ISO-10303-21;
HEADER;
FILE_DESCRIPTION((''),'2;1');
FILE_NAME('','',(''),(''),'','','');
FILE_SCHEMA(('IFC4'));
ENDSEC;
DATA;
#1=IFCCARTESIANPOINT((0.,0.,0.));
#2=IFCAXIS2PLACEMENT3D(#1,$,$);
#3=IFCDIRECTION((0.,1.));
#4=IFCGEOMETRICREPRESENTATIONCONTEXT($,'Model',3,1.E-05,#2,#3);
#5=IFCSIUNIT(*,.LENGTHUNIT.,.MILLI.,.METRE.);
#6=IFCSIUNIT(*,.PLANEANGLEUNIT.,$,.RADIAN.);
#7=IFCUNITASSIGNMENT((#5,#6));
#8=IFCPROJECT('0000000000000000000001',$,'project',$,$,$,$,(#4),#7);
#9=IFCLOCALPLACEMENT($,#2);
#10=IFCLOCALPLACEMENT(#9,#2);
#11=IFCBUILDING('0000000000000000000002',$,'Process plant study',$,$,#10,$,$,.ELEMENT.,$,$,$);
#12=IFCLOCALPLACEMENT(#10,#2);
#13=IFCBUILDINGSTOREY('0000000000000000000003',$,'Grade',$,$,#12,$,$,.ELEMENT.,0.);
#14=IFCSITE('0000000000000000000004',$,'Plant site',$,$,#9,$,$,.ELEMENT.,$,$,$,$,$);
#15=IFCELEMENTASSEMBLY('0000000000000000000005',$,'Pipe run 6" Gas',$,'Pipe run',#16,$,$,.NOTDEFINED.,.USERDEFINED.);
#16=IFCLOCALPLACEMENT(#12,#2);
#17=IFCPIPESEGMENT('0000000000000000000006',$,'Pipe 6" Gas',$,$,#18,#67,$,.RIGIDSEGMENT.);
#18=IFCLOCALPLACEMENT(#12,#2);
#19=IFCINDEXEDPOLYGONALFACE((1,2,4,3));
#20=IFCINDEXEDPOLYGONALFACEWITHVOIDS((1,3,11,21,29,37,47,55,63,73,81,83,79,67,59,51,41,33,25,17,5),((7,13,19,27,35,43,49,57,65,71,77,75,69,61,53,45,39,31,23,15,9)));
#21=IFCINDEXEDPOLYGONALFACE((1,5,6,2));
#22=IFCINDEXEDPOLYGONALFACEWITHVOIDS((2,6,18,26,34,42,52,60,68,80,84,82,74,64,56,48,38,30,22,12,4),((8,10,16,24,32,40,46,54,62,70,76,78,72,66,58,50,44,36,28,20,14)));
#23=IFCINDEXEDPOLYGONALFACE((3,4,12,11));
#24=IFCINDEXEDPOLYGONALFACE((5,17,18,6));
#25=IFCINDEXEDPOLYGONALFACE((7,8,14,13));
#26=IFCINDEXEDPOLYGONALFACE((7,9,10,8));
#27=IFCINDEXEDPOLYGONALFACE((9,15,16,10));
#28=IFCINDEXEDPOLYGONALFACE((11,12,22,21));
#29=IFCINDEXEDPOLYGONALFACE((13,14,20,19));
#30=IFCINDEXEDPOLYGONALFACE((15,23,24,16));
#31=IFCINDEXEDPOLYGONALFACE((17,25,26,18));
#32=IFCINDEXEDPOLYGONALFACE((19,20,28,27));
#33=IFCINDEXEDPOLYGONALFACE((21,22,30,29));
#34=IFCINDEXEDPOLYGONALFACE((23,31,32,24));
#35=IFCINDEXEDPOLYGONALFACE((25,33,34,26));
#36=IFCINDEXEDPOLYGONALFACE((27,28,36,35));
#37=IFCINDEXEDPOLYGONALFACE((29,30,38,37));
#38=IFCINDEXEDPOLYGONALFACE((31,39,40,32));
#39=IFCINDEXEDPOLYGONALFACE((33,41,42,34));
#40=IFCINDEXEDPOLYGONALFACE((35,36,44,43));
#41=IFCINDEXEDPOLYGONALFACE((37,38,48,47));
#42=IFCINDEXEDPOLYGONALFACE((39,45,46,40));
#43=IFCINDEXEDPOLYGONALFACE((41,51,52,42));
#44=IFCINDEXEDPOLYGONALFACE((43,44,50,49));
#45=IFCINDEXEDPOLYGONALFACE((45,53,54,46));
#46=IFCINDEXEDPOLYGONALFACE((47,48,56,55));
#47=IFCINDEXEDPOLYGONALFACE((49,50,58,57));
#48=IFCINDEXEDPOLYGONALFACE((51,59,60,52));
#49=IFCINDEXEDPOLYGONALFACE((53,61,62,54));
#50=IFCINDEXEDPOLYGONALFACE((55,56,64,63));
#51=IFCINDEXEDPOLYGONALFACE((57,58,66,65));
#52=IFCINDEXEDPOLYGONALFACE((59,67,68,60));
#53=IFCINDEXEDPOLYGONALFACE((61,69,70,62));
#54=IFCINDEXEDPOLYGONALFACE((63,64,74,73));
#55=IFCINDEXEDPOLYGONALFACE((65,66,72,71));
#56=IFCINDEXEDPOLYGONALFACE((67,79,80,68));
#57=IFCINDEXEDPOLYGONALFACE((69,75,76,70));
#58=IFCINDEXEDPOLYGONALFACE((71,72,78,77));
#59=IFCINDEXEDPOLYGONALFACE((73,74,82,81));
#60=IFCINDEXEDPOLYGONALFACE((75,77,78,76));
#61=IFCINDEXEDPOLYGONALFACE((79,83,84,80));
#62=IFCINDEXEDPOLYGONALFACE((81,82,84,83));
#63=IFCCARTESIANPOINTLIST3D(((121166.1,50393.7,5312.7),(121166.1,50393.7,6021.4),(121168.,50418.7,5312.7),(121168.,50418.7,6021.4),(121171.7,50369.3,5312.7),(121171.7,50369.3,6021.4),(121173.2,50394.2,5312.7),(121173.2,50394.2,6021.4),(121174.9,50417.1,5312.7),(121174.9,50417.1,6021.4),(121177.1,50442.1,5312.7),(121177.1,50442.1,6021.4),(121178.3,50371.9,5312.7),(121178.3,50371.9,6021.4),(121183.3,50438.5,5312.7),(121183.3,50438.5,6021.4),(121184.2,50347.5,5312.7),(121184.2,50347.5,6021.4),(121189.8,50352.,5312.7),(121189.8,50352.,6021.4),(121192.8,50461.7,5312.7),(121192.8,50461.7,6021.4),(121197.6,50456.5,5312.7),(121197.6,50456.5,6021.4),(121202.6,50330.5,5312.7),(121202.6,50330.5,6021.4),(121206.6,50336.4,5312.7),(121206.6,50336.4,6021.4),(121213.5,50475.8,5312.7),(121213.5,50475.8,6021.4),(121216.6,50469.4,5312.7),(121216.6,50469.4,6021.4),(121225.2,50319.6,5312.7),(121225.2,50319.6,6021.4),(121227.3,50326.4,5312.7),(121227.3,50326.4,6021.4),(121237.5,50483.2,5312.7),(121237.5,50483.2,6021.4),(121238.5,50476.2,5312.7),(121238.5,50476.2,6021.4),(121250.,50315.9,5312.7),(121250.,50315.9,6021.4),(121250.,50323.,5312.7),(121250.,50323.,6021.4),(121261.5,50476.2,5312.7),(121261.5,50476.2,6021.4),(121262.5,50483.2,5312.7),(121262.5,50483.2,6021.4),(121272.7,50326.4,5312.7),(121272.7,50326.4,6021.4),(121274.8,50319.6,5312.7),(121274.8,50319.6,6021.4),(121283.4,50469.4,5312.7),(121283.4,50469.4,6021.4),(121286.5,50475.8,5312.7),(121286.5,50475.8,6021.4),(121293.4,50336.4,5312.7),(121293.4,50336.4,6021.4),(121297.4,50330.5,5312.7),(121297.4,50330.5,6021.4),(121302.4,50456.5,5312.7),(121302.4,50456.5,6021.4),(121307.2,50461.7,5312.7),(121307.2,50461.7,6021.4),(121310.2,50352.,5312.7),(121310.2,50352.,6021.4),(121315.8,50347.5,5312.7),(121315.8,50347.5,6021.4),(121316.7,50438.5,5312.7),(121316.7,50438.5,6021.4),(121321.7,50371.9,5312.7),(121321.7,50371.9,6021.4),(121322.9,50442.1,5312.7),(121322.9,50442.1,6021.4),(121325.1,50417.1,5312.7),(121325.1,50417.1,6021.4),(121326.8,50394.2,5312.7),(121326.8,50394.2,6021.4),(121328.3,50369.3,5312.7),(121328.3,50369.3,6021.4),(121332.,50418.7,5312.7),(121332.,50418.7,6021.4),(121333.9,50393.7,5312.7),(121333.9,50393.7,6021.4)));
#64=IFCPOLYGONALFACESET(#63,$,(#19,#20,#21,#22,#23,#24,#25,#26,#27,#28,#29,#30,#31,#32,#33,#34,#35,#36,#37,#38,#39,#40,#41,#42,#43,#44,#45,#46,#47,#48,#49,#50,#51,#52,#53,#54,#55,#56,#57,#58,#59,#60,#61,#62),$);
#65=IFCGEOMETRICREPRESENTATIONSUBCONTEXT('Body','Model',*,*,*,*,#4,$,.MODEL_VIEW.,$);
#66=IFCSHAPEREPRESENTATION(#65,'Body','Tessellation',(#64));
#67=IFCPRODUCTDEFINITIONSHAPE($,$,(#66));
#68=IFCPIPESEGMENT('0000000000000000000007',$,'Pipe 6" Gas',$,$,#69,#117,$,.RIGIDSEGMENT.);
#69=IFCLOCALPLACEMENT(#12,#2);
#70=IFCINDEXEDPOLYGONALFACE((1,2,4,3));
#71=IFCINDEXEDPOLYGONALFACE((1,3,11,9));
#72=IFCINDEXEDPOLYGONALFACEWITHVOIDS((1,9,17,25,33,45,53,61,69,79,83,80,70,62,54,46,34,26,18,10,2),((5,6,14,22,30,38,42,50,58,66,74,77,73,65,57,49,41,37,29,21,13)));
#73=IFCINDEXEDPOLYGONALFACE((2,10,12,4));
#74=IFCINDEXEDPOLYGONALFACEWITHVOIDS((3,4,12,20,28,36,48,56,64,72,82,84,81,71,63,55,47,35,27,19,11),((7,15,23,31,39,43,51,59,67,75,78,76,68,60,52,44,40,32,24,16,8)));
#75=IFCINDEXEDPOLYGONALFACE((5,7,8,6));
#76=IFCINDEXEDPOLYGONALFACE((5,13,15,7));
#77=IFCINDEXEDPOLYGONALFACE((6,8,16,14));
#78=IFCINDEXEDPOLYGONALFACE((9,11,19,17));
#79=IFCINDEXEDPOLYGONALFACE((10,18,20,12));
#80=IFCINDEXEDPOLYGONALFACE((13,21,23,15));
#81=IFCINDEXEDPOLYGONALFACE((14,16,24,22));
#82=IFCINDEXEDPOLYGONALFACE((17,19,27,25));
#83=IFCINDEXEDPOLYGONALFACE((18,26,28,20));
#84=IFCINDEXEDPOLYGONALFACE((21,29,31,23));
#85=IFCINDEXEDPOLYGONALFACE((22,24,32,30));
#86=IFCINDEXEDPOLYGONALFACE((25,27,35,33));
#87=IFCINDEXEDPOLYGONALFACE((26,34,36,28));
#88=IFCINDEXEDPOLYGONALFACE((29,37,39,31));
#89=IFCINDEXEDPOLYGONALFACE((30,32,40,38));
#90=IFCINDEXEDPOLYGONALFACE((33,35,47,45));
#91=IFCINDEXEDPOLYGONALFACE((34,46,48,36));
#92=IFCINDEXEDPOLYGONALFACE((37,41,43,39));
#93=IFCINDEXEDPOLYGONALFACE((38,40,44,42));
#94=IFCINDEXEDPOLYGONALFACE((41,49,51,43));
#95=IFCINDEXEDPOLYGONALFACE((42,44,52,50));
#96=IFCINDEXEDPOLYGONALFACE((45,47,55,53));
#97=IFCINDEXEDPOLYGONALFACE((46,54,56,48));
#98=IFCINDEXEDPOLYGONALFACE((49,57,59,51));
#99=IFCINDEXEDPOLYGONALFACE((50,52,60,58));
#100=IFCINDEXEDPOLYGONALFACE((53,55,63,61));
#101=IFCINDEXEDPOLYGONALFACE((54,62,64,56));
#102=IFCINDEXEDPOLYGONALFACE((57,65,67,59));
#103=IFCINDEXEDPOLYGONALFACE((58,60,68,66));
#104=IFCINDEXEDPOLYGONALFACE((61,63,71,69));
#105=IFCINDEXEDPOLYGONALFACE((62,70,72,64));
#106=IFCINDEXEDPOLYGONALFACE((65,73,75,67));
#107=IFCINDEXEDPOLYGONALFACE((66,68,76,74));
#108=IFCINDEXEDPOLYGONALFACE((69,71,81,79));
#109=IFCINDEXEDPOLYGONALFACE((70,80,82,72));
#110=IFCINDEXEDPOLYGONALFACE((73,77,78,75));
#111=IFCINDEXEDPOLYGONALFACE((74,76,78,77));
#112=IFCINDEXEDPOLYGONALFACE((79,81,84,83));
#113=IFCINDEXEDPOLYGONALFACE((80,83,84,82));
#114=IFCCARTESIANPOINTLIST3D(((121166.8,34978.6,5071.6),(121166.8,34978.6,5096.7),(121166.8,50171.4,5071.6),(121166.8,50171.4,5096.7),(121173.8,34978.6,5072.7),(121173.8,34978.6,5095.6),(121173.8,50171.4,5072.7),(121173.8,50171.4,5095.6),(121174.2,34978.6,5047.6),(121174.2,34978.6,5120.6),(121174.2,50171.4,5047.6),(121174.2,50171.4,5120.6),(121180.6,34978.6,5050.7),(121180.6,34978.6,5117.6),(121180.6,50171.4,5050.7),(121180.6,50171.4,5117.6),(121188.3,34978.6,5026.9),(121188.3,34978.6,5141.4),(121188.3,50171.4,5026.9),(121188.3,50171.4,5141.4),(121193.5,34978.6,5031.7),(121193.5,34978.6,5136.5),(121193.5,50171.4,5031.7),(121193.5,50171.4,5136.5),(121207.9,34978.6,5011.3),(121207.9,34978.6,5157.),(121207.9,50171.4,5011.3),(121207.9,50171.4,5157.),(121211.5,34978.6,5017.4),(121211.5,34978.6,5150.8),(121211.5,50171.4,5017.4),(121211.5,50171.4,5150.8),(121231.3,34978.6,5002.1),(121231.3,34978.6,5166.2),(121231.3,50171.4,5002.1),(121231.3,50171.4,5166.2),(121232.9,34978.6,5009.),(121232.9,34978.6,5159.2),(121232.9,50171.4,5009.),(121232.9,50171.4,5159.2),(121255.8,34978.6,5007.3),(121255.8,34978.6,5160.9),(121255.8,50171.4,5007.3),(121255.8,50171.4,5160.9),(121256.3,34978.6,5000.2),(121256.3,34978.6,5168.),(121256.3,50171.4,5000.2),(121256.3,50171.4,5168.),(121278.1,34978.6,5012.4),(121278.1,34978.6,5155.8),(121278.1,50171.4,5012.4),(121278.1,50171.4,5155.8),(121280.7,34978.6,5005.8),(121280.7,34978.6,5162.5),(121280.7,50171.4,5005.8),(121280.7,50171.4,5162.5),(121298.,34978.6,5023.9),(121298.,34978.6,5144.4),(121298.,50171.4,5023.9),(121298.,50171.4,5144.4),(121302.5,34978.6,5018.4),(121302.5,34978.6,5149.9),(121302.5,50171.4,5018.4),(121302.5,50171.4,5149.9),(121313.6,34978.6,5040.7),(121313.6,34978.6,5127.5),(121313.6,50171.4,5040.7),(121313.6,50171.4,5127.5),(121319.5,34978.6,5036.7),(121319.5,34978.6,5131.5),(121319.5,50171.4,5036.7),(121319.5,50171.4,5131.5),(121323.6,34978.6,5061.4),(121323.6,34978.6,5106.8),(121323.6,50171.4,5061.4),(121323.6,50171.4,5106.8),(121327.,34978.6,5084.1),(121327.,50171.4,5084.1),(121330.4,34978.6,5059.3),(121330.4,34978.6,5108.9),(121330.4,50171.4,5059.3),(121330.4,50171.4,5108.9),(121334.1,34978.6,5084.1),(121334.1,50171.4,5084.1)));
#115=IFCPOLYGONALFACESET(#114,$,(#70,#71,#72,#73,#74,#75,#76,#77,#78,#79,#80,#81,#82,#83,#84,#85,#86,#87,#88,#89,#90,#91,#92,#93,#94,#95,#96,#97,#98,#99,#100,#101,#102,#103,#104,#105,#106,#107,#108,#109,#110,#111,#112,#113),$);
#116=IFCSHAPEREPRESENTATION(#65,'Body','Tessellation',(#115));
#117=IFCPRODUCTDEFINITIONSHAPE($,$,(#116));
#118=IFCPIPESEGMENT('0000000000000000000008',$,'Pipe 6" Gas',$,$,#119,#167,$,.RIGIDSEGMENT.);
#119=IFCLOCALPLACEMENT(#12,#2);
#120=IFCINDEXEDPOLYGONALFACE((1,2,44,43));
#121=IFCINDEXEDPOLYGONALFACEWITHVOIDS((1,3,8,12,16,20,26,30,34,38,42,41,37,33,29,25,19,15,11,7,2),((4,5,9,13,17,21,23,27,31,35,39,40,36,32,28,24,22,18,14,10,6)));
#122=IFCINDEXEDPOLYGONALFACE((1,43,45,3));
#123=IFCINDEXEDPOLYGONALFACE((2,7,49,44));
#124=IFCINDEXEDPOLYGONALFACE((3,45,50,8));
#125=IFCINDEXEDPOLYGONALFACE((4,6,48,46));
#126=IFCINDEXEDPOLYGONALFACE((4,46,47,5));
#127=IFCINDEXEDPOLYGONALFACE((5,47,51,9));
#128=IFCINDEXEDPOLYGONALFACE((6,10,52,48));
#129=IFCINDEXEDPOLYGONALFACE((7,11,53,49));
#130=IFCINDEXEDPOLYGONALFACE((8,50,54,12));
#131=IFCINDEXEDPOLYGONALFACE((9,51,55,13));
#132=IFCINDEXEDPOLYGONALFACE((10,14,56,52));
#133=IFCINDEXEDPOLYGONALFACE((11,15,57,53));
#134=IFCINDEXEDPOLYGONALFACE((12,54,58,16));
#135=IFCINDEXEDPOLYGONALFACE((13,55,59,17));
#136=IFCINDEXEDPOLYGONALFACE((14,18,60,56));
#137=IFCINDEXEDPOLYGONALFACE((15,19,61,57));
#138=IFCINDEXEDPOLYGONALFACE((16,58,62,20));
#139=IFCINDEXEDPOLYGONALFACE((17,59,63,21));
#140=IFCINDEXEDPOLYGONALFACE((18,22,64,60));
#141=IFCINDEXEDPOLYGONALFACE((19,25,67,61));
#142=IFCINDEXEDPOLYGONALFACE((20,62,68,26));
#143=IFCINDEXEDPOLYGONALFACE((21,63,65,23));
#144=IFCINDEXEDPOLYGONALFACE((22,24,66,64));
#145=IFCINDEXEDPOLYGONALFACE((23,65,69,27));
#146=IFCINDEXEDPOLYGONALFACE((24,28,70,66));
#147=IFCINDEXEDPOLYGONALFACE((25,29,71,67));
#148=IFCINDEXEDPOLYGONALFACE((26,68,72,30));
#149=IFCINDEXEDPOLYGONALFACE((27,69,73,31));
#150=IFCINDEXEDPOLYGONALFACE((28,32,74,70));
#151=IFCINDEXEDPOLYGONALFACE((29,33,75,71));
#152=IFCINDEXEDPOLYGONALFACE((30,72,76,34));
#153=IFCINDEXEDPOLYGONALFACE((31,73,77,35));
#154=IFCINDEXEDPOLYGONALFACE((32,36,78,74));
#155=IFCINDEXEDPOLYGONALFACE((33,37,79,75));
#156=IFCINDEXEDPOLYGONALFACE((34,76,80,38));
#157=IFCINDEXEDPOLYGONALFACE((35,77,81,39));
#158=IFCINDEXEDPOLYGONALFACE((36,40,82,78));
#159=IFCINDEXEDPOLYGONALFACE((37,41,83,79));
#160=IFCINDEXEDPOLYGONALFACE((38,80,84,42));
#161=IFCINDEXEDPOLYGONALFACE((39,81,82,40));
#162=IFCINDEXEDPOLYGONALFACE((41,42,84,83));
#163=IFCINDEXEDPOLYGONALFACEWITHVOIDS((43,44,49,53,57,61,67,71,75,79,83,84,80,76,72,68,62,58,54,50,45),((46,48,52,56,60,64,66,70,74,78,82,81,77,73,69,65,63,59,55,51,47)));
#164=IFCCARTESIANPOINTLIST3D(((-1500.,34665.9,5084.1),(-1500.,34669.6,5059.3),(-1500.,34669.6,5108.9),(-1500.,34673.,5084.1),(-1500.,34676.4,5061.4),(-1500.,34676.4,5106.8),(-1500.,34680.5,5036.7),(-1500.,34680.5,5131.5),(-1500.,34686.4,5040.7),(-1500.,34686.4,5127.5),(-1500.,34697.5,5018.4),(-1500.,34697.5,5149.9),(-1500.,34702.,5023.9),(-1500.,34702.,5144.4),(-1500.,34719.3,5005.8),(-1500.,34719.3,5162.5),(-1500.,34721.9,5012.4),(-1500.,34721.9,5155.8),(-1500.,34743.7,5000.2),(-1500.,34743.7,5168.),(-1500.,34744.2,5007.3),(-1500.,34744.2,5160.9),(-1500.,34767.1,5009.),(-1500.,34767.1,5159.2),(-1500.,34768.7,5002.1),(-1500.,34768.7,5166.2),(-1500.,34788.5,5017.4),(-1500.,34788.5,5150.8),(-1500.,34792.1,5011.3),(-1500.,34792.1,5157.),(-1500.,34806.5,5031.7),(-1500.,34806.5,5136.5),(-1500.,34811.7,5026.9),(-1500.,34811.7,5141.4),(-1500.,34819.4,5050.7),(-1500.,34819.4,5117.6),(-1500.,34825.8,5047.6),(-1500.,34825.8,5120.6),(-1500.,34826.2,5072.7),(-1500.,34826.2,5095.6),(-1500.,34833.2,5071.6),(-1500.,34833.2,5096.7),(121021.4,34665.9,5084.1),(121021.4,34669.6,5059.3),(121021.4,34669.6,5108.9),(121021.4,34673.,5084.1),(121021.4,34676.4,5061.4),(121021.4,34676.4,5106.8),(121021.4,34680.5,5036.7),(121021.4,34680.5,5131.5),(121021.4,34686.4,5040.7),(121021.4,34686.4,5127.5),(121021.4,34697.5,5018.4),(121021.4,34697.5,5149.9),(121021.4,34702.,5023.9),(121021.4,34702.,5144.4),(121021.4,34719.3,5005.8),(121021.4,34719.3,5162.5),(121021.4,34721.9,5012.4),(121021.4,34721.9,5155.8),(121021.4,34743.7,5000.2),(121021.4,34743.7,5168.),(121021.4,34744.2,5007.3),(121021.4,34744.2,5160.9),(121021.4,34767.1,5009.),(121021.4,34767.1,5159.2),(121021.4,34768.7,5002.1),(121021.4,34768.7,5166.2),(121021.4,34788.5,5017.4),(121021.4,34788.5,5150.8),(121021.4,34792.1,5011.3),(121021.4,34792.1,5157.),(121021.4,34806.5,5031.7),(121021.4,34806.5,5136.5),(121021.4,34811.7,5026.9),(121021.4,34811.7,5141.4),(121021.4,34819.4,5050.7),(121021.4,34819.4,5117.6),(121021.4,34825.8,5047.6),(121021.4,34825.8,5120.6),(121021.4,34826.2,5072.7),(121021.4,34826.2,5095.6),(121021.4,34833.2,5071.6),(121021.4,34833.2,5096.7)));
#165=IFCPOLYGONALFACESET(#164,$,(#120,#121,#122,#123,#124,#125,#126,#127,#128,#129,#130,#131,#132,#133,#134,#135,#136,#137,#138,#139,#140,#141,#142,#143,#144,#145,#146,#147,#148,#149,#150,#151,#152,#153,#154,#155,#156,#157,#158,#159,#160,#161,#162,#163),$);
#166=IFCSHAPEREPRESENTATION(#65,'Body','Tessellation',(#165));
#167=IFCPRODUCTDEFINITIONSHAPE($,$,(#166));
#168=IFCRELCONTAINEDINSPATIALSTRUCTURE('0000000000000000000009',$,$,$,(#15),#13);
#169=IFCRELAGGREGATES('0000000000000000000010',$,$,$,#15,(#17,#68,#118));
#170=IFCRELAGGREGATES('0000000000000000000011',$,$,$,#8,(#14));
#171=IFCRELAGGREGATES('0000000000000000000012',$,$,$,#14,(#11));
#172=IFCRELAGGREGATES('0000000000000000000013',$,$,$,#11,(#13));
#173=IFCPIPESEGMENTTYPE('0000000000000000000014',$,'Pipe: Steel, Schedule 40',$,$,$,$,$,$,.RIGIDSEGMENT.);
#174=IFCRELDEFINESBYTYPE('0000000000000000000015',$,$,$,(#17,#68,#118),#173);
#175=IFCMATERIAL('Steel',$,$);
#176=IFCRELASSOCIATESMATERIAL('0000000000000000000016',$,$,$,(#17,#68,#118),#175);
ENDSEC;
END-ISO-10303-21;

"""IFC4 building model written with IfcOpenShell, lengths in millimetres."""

from ifc_helpers import new_model, si_unit, direction, frame, origin, origin_with_axes, origin_2d, place, context, subcontext, project, spatial, hollow_circle, extrude, material, type_object, element, aggregate, save


model = new_model("IFC4")

# Units and contexts
model_context = context("Model", 3, precision=1e-05, world=origin(), true_north=direction((0.0, 1.0)))
body_context = subcontext(model_context, "Body", "Model", "MODEL_VIEW")
ifc_project = project(units=[si_unit("LENGTHUNIT", "METRE", prefix="MILLI"), si_unit("PLANEANGLEUNIT", "RADIAN")], contexts=[model_context])

# Site, building, storey
site_placement = place(None, origin())
site = spatial("IfcSite", under=ifc_project, at=site_placement, Name="Plant site", CompositionType="ELEMENT")
building_placement = place(site_placement, origin())
building = spatial("IfcBuilding", under=site, at=building_placement, Name="Process plant study", CompositionType="ELEMENT")
storey_placement = place(building_placement, origin())
storey = spatial("IfcBuildingStorey", under=building, at=storey_placement, Name="Grade", CompositionType="ELEMENT", Elevation=0.0)

# Element assembly, pipe segments
assembly_1_placement = place(storey_placement, origin_with_axes())
assembly_1 = element("IfcElementAssembly", 1, at=assembly_1_placement, inside=storey, Name="Pipe run 6\" Gas", ObjectType="Pipe run", AssemblyPlace="NOTDEFINED", PredefinedType="USERDEFINED")
ifc_material = material(Name="Steel")
pipe_segment_type = type_object("IfcPipeSegmentType", Name="Pipe: Steel, Schedule 40", PredefinedType="RIGIDSEGMENT")
pipe_segment_1_placement = place(storey_placement, origin_with_axes())
pipe_segment_1 = element("IfcPipeSegment", 2, at=pipe_segment_1_placement, type_object=pipe_segment_type, material=ifc_material, Name="Pipe 6\" Gas", PredefinedType="RIGIDSEGMENT", context=body_context, shape_type="SweptSolid", body=[
    extrude(hollow_circle(Radius=84.1, WallThickness=7.1, at=origin_2d()), frame((121250.0, 50400.0, 6021.4), z_axis=(0.0, 0.0, -1.0), x_axis=(0.0, -1.0, 0.0)), (0.0, 0.0, 1.0), 708.7),
])
pipe_segment_2_placement = place(storey_placement, origin_with_axes())
pipe_segment_2 = element("IfcPipeSegment", 3, at=pipe_segment_2_placement, type_object=pipe_segment_type, material=ifc_material, Name="Pipe 6\" Gas", PredefinedType="RIGIDSEGMENT", context=body_context, shape_type="SweptSolid", body=[
    extrude(hollow_circle(Radius=84.1, WallThickness=7.1, at=origin_2d()), frame((121250.0, 50171.4, 5084.1), z_axis=(0.0, -1.0, 0.0), x_axis=(1.0, 0.0, 0.0)), (0.0, 0.0, 1.0), 15192.8),
])
pipe_segment_3_placement = place(storey_placement, origin_with_axes())
pipe_segment_3 = element("IfcPipeSegment", 4, at=pipe_segment_3_placement, type_object=pipe_segment_type, material=ifc_material, Name="Pipe 6\" Gas", PredefinedType="RIGIDSEGMENT", context=body_context, shape_type="SweptSolid", body=[
    extrude(hollow_circle(Radius=84.1, WallThickness=7.1, at=origin_2d()), frame((121021.4, 34750.0, 5084.1), z_axis=(-1.0, 0.0, 0.0), x_axis=(0.0, -1.0, 0.0)), (0.0, 0.0, 1.0), 122521.4),
])

aggregate(assembly_1, [pipe_segment_1, pipe_segment_2, pipe_segment_3])

save(model, "model.ifc")
